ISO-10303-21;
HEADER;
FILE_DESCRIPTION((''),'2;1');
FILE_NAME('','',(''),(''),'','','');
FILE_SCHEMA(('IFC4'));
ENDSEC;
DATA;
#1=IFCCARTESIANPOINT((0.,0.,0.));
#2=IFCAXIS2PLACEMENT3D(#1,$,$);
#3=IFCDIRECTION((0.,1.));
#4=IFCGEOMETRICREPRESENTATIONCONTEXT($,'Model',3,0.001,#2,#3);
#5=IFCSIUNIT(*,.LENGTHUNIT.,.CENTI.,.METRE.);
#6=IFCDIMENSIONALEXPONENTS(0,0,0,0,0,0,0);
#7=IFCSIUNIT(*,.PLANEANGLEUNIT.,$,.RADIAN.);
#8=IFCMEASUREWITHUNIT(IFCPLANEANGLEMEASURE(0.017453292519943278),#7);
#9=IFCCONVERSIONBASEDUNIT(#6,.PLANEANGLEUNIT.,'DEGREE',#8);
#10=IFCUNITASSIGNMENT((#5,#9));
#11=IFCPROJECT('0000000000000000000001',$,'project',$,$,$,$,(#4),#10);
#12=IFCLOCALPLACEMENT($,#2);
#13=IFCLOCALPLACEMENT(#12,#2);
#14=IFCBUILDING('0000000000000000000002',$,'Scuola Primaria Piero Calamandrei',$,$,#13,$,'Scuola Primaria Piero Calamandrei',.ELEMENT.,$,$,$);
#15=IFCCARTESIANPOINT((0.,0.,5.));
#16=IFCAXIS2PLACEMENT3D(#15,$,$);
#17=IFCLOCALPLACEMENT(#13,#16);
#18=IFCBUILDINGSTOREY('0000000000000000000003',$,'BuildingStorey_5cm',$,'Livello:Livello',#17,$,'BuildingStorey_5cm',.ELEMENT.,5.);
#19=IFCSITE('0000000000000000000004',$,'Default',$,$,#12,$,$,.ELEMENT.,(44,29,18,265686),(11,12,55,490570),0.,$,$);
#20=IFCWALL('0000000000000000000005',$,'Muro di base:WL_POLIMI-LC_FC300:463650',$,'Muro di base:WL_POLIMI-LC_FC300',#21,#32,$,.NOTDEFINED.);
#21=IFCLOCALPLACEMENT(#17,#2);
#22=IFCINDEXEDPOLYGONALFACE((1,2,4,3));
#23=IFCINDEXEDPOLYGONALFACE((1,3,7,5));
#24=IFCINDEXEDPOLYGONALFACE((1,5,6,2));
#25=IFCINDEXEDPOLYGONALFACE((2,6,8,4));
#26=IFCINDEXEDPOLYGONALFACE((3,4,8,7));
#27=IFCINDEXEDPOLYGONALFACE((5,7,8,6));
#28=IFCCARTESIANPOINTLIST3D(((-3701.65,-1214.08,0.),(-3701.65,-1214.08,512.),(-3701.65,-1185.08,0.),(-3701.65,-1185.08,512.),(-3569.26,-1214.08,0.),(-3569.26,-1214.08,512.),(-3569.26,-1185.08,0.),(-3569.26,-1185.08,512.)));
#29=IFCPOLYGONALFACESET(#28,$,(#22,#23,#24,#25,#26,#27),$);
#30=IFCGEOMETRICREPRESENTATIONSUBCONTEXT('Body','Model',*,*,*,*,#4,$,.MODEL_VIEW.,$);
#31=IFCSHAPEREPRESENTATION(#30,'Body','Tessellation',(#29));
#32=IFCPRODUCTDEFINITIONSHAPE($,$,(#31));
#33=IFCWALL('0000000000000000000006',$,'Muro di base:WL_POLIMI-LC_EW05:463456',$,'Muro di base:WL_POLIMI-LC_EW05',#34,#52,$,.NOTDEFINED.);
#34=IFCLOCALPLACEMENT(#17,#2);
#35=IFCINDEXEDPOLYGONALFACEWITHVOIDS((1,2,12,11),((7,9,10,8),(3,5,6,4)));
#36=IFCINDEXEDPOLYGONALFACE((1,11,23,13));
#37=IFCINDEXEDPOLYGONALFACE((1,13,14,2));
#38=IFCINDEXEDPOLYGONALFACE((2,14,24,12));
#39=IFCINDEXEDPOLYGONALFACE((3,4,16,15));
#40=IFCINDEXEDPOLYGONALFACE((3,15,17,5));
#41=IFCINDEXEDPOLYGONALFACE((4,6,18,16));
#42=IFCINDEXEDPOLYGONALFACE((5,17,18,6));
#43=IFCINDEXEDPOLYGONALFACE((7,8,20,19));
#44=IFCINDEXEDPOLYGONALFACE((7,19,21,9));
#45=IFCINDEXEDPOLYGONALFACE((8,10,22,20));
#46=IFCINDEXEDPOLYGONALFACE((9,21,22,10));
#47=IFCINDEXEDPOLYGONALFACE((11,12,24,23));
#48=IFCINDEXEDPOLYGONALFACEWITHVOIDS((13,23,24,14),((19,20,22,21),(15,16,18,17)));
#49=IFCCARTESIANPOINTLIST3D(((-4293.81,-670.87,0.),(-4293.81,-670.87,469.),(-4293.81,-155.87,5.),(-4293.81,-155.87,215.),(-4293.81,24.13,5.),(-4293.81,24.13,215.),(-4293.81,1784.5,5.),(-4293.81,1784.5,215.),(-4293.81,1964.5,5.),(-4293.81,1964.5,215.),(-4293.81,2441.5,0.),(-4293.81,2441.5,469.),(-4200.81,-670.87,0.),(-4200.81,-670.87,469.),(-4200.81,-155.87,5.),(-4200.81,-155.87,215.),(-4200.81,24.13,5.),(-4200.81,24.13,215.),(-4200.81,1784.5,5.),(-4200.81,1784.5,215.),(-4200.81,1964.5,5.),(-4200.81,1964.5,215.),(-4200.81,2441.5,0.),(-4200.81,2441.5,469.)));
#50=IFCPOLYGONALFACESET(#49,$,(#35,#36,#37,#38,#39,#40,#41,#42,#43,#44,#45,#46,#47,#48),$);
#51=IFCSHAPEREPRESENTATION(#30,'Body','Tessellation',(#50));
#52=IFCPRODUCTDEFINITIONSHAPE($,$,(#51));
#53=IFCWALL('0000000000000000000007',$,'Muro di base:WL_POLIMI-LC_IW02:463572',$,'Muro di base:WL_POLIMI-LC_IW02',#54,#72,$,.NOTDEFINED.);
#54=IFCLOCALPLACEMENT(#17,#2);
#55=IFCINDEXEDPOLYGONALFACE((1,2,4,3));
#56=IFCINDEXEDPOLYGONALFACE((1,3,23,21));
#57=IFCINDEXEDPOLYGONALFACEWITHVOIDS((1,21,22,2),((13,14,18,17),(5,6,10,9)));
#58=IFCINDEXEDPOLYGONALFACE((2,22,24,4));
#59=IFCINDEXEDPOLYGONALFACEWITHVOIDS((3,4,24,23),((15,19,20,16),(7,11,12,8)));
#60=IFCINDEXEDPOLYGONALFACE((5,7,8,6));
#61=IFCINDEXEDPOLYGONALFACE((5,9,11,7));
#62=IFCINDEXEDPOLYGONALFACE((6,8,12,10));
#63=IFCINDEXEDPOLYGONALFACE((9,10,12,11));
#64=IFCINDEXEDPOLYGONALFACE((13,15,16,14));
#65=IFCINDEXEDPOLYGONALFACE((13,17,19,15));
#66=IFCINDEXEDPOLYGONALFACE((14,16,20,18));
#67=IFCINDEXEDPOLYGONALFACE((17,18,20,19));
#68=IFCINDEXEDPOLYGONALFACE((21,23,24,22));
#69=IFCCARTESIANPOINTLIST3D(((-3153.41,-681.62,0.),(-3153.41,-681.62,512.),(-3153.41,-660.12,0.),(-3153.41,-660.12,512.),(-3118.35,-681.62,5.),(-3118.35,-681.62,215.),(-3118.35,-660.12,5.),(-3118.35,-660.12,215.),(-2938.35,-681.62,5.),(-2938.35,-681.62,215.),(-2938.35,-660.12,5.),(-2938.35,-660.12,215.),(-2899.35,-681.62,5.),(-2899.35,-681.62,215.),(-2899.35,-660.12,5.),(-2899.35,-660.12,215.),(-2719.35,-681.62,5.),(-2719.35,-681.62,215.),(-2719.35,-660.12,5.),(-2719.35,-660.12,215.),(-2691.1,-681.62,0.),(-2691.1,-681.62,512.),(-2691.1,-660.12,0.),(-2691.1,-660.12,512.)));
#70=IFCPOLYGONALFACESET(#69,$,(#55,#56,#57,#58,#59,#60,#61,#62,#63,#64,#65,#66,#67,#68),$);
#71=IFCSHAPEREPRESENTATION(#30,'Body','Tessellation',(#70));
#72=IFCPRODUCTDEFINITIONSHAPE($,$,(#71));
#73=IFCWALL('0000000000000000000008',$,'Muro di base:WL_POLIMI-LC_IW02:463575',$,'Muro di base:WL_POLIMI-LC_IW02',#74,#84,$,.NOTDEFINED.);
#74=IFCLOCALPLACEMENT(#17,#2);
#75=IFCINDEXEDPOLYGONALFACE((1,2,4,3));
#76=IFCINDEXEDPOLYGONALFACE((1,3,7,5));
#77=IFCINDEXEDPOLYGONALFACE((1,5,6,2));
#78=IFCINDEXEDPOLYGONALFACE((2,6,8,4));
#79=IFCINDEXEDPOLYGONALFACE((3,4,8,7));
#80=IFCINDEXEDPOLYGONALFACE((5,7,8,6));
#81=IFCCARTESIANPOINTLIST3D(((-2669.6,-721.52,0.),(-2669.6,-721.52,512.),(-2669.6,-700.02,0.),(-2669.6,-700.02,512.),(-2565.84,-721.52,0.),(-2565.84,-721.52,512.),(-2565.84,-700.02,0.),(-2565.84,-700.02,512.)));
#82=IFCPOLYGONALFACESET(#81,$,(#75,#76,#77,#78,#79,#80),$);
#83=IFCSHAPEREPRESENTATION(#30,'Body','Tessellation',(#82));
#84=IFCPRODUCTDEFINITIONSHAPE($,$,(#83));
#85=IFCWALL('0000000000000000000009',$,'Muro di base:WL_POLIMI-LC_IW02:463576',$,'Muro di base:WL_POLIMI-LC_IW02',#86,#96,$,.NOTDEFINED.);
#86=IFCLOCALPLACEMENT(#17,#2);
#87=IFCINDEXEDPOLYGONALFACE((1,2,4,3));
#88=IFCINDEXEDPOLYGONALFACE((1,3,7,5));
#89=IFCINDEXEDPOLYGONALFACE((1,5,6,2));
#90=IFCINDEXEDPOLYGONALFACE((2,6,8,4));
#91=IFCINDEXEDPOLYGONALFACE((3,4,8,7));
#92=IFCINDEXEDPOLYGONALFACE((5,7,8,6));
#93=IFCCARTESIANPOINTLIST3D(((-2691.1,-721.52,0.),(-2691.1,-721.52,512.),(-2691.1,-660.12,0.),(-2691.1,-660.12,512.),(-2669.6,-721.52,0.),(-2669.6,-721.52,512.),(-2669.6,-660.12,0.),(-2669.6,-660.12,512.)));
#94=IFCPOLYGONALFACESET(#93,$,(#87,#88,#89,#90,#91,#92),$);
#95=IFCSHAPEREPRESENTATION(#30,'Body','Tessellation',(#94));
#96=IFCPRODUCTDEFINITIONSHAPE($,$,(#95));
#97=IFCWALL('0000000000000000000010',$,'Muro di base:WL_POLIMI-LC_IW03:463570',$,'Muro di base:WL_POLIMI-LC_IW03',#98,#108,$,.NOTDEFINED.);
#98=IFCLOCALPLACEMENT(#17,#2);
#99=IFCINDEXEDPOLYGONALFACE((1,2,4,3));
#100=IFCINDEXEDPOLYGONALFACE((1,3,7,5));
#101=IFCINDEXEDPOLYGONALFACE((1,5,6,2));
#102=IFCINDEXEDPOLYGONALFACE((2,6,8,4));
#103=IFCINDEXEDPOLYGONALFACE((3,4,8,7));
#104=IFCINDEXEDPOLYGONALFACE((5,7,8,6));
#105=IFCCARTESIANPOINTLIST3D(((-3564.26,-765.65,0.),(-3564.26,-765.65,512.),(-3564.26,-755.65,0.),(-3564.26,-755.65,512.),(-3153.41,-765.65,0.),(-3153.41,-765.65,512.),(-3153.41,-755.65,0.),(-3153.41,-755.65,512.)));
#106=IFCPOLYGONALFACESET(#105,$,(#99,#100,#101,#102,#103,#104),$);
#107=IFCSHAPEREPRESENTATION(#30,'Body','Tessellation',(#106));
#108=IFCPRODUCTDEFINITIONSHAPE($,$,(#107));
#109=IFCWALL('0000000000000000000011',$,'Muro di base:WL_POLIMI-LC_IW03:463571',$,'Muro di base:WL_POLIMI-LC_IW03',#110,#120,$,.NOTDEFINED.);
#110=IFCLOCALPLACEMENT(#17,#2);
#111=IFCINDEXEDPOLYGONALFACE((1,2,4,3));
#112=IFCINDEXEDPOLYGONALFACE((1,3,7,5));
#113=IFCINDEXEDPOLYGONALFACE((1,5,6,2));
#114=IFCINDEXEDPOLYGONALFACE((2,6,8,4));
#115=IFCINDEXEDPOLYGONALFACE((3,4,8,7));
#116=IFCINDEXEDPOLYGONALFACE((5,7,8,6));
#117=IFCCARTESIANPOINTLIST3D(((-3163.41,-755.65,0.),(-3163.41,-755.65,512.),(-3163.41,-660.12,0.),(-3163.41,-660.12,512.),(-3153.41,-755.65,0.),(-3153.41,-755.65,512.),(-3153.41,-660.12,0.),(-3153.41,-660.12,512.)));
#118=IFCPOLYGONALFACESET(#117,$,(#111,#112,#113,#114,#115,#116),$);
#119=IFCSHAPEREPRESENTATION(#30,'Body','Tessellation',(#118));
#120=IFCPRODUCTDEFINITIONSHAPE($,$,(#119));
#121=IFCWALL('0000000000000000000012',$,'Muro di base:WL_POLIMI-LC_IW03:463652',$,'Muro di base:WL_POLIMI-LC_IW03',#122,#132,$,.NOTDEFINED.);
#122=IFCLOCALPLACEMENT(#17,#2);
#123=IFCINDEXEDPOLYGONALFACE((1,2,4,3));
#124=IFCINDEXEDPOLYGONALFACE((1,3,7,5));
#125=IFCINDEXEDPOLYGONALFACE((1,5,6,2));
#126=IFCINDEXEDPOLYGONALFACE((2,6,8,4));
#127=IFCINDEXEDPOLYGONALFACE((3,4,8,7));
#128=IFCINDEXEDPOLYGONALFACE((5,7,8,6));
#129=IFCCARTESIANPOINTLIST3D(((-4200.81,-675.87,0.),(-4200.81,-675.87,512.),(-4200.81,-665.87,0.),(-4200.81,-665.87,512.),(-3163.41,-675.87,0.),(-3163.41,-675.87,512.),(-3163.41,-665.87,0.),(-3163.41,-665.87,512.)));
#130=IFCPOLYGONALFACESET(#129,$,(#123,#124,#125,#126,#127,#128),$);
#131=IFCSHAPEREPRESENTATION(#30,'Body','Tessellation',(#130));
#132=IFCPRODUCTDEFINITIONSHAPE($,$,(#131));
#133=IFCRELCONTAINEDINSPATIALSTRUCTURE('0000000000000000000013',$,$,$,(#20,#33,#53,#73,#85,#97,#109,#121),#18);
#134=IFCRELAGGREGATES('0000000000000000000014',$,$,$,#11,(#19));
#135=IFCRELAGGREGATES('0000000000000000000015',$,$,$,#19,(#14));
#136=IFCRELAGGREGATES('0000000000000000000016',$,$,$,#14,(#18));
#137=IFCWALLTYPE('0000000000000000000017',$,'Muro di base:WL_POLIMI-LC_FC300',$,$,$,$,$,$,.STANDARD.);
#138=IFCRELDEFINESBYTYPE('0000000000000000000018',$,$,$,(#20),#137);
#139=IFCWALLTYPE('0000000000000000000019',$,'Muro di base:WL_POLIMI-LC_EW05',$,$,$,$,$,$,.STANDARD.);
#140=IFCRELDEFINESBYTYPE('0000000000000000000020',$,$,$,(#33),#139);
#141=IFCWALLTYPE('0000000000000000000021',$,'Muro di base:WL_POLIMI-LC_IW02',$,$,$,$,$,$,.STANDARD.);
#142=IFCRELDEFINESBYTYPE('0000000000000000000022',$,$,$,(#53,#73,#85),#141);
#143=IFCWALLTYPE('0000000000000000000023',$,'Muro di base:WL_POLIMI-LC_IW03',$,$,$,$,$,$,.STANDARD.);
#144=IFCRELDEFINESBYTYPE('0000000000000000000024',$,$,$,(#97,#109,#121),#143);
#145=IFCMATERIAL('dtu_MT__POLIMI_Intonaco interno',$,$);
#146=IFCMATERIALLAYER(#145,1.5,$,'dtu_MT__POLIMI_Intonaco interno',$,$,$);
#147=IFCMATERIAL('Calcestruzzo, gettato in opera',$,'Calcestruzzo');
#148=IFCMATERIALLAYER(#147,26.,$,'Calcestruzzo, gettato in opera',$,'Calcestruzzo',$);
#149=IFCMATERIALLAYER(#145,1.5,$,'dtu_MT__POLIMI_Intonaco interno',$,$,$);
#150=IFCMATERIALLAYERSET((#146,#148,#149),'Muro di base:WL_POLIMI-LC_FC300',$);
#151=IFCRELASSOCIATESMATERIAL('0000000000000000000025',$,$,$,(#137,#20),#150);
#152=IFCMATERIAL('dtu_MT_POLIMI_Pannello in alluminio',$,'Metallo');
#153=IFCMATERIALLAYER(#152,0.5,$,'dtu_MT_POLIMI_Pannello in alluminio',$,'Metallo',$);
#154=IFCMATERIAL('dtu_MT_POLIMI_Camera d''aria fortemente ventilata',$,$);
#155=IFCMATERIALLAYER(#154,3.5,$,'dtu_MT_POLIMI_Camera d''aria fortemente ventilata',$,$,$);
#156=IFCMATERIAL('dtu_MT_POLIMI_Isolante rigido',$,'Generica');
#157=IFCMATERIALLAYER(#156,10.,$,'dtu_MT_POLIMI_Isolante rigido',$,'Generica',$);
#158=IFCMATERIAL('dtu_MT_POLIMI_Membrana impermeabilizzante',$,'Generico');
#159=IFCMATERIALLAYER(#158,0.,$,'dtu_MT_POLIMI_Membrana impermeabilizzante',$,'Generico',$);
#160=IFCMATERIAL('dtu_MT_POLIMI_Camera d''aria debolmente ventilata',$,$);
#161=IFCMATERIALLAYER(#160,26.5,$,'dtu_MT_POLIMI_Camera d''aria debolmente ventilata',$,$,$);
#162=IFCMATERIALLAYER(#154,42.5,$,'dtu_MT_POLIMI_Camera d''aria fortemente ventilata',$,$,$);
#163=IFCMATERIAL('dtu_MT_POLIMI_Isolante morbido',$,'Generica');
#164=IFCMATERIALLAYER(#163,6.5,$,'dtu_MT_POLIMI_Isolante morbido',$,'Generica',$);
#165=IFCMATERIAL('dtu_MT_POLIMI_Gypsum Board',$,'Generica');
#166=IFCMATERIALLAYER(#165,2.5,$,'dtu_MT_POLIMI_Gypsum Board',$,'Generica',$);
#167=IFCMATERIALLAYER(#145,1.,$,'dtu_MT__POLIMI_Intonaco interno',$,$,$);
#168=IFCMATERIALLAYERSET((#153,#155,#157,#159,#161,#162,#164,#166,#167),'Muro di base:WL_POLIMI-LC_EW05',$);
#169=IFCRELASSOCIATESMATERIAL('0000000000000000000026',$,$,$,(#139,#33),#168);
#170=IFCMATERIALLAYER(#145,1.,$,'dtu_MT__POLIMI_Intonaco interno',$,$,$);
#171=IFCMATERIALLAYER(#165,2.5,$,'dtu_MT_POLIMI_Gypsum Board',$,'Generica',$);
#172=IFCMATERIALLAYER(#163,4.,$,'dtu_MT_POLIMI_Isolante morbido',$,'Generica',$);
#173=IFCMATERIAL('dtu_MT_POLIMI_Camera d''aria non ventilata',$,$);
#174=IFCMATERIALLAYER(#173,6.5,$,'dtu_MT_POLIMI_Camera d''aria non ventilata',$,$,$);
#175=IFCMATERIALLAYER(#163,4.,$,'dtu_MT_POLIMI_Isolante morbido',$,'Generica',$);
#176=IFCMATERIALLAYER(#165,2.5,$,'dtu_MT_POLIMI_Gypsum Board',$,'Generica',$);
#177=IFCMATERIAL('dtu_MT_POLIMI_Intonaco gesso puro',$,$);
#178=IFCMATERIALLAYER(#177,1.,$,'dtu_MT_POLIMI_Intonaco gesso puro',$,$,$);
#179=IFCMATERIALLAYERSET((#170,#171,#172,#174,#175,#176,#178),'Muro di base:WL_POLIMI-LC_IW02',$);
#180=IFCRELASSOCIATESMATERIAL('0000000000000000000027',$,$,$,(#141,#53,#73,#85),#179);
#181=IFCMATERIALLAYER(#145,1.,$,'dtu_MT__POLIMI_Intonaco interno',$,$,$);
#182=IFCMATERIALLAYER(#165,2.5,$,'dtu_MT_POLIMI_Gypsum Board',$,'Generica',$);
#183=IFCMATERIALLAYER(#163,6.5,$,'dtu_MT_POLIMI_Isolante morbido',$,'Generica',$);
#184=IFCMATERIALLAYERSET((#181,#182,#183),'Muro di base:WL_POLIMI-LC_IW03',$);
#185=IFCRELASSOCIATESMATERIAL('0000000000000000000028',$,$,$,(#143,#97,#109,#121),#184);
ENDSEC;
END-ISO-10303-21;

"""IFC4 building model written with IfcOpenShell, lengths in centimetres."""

from ifc_helpers import new_model, entity, si_unit, converted_unit, direction, frame, frame_2d, origin, place, context, subcontext, project, spatial, polyline, rectangle, extrude, clip, bounded_halfspace, material, layer, layer_set, layer_usage, type_object, element, save


model = new_model("IFC4")

# Units and contexts
model_context = context("Model", 3, precision=0.001, world=origin(), true_north=direction((0.0, 1.0)))
body_context = subcontext(model_context, "Body", "Model", "MODEL_VIEW")
ifc_project = project(units=[si_unit("LENGTHUNIT", "METRE", prefix="CENTI"), converted_unit("PLANEANGLEUNIT", "DEGREE", entity("IfcPlaneAngleMeasure", 0.017453292519943278), si_unit("PLANEANGLEUNIT", "RADIAN"), dimensions=[0, 0, 0, 0, 0, 0, 0])], contexts=[model_context])

# Site, building, storey
site_placement = place(None, origin())
site = spatial("IfcSite", under=ifc_project, at=site_placement, Name="Default", CompositionType="ELEMENT", RefLatitude=(44, 29, 18, 265686), RefLongitude=(11, 12, 55, 490570), RefElevation=0.0)
building_placement = place(site_placement, origin())
building = spatial("IfcBuilding", under=site, at=building_placement, Name="Scuola Primaria Piero Calamandrei", LongName="Scuola Primaria Piero Calamandrei", CompositionType="ELEMENT")
storey_placement = place(building_placement, frame((0.0, 0.0, 5.0)))
storey = spatial("IfcBuildingStorey", under=building, at=storey_placement, Name="BuildingStorey_5cm", ObjectType="Livello:Livello", LongName="BuildingStorey_5cm", CompositionType="ELEMENT", Elevation=5.0)

# Shared definitions
ifc_material_1 = material(Name="dtu_MT_POLIMI_Isolante rigido", Category="Generica")
ifc_material_2 = material(Name="dtu_MT__POLIMI_Intonaco interno")

# Shared definitions
ifc_material_3 = material(Name="dtu_MT_POLIMI_Intonaco gesso puro")

# Wall
ifc_layer_1 = layer(ifc_material_2, 1.5, Name="dtu_MT__POLIMI_Intonaco interno")
ifc_material_4 = material(Name="Calcestruzzo, gettato in opera", Category="Calcestruzzo")
ifc_layer_2 = layer(ifc_material_4, 26.0, Name="Calcestruzzo, gettato in opera", Category="Calcestruzzo")
ifc_layer_3 = layer(ifc_material_2, 1.5, Name="dtu_MT__POLIMI_Intonaco interno")
ifc_layer_set_1 = layer_set([ifc_layer_1, ifc_layer_2, ifc_layer_3], Name="Muro di base:WL_POLIMI-LC_FC300")
wall_type_1 = type_object("IfcWallType", Name="Muro di base:WL_POLIMI-LC_FC300", PredefinedType="STANDARD", material=ifc_layer_set_1)
ifc_layer_usage_1 = layer_usage(ifc_layer_set_1, "AXIS2", "NEGATIVE", 14.5)
wall_1_placement = place(storey_placement, frame((-3701.65, -1199.58, 0.0)))
element("IfcWall", 1, at=wall_1_placement, inside=storey, type_object=wall_type_1, material=ifc_layer_usage_1, Name="Muro di base:WL_POLIMI-LC_FC300:463650", ObjectType="Muro di base:WL_POLIMI-LC_FC300", PredefinedType="NOTDEFINED", context=body_context, shape_type="SweptSolid", body=[
    extrude(rectangle(XDim=132.39, YDim=29.0, at=frame_2d((66.2, 0.0), x_axis=(-1.0, 0.0))), origin(), (0.0, 0.0, 1.0), 512.0),
])

# Walls, openings
ifc_material_5 = material(Name="dtu_MT_POLIMI_Pannello in alluminio", Category="Metallo")
ifc_layer_4 = layer(ifc_material_5, 0.5, Name="dtu_MT_POLIMI_Pannello in alluminio", Category="Metallo")
ifc_material_6 = material(Name="dtu_MT_POLIMI_Camera d'aria fortemente ventilata")
ifc_layer_5 = layer(ifc_material_6, 3.5, Name="dtu_MT_POLIMI_Camera d'aria fortemente ventilata")
ifc_layer_6 = layer(ifc_material_1, 10.0, Name="dtu_MT_POLIMI_Isolante rigido", Category="Generica")
ifc_material_7 = material(Name="dtu_MT_POLIMI_Membrana impermeabilizzante", Category="Generico")
ifc_layer_7 = layer(ifc_material_7, 0.0, Name="dtu_MT_POLIMI_Membrana impermeabilizzante", Category="Generico")
ifc_material_8 = material(Name="dtu_MT_POLIMI_Camera d'aria debolmente ventilata")
ifc_layer_8 = layer(ifc_material_8, 26.5, Name="dtu_MT_POLIMI_Camera d'aria debolmente ventilata")
ifc_layer_9 = layer(ifc_material_6, 42.5, Name="dtu_MT_POLIMI_Camera d'aria fortemente ventilata")
ifc_material_9 = material(Name="dtu_MT_POLIMI_Isolante morbido", Category="Generica")
ifc_layer_10 = layer(ifc_material_9, 6.5, Name="dtu_MT_POLIMI_Isolante morbido", Category="Generica")
ifc_material_10 = material(Name="dtu_MT_POLIMI_Gypsum Board", Category="Generica")
ifc_layer_11 = layer(ifc_material_10, 2.5, Name="dtu_MT_POLIMI_Gypsum Board", Category="Generica")
ifc_layer_12 = layer(ifc_material_2, 1.0, Name="dtu_MT__POLIMI_Intonaco interno")
ifc_layer_set_2 = layer_set([ifc_layer_4, ifc_layer_5, ifc_layer_6, ifc_layer_7, ifc_layer_8, ifc_layer_9, ifc_layer_10, ifc_layer_11, ifc_layer_12], Name="Muro di base:WL_POLIMI-LC_EW05")
ifc_layer_usage_2 = layer_usage(ifc_layer_set_2, "AXIS2", "NEGATIVE", 46.5)
wall_type_2 = type_object("IfcWallType", Name="Muro di base:WL_POLIMI-LC_EW05", PredefinedType="STANDARD", material=ifc_layer_set_2)
wall_2_placement = place(storey_placement, frame((-4247.31, -670.87, 0.0), z_axis=(0.0, 0.0, 1.0), x_axis=(0.0, 1.0, 0.0)))
wall_2 = element("IfcWall", 2, at=wall_2_placement, inside=storey, type_object=wall_type_2, material=ifc_layer_usage_2, Name="Muro di base:WL_POLIMI-LC_EW05:463456", ObjectType="Muro di base:WL_POLIMI-LC_EW05", PredefinedType="NOTDEFINED", context=body_context, shape_type="Clipping", body=[
    clip(extrude(rectangle(XDim=3112.37, YDim=93.0, at=frame_2d((1556.19, 0.0), x_axis=(-1.0, 0.0))), origin(), (0.0, 0.0, 1.0), 469.0), bounded_halfspace(frame((1855.45, -46.5, 469.0), z_axis=(0.0, 0.0, -1.0), x_axis=(0.0, -1.0, 0.0)), True, frame((1855.45, -46.5, 469.0)), polyline([(0.0, 0.0), (1256.92, 0.0), (1256.92, 93.0), (0.0, 93.0), (0.0, 0.0)]))),
])
opening_1_placement = place(wall_2_placement, frame((2455.37, -46.5, 5.0)))
element("IfcOpeningElement", 3, at=opening_1_placement, cuts=wall_2, PredefinedType="OPENING", context=body_context, shape_type="SweptSolid", body=[
    extrude(rectangle(XDim=210.0, YDim=180.0, at=frame_2d((105.0, 90.0), x_axis=(-1.0, 0.0))), frame((0.0, 0.0, 0.0), z_axis=(0.0, 1.0, 0.0), x_axis=(0.0, 0.0, 1.0)), (0.0, 0.0, 1.0), 93.0),
])
opening_2_placement = place(wall_2_placement, frame((515.0, -46.5, 5.0)))
element("IfcOpeningElement", 4, at=opening_2_placement, cuts=wall_2, PredefinedType="OPENING", context=body_context, shape_type="SweptSolid", body=[
    extrude(rectangle(XDim=210.0, YDim=180.0, at=frame_2d((105.0, 90.0), x_axis=(-1.0, 0.0))), frame((0.0, 0.0, 0.0), z_axis=(0.0, 1.0, 0.0), x_axis=(0.0, 0.0, 1.0)), (0.0, 0.0, 1.0), 93.0),
])
ifc_layer_13 = layer(ifc_material_2, 1.0, Name="dtu_MT__POLIMI_Intonaco interno")
ifc_layer_14 = layer(ifc_material_10, 2.5, Name="dtu_MT_POLIMI_Gypsum Board", Category="Generica")
ifc_layer_15 = layer(ifc_material_9, 4.0, Name="dtu_MT_POLIMI_Isolante morbido", Category="Generica")
ifc_material_11 = material(Name="dtu_MT_POLIMI_Camera d'aria non ventilata")
ifc_layer_16 = layer(ifc_material_11, 6.5, Name="dtu_MT_POLIMI_Camera d'aria non ventilata")
ifc_layer_17 = layer(ifc_material_9, 4.0, Name="dtu_MT_POLIMI_Isolante morbido", Category="Generica")
ifc_layer_18 = layer(ifc_material_10, 2.5, Name="dtu_MT_POLIMI_Gypsum Board", Category="Generica")
ifc_layer_19 = layer(ifc_material_3, 1.0, Name="dtu_MT_POLIMI_Intonaco gesso puro")
ifc_layer_set_3 = layer_set([ifc_layer_13, ifc_layer_14, ifc_layer_15, ifc_layer_16, ifc_layer_17, ifc_layer_18, ifc_layer_19], Name="Muro di base:WL_POLIMI-LC_IW02")
ifc_layer_usage_3 = layer_usage(ifc_layer_set_3, "AXIS2", "NEGATIVE", 10.75)
wall_type_3 = type_object("IfcWallType", Name="Muro di base:WL_POLIMI-LC_IW02", PredefinedType="STANDARD", material=ifc_layer_set_3)
wall_3_placement = place(storey_placement, frame((-3153.41, -670.87, 0.0)))
wall_3 = element("IfcWall", 5, at=wall_3_placement, inside=storey, type_object=wall_type_3, material=ifc_layer_usage_3, Name="Muro di base:WL_POLIMI-LC_IW02:463572", ObjectType="Muro di base:WL_POLIMI-LC_IW02", PredefinedType="NOTDEFINED", context=body_context, shape_type="SweptSolid", body=[
    extrude(rectangle(XDim=462.31, YDim=21.5, at=frame_2d((231.16, 0.0), x_axis=(-1.0, 0.0))), origin(), (0.0, 0.0, 1.0), 512.0),
])
opening_3_placement = place(wall_3_placement, frame((434.06, 10.75, 5.0)))
element("IfcOpeningElement", 6, at=opening_3_placement, cuts=wall_3, PredefinedType="OPENING", context=body_context, shape_type="SweptSolid", body=[
    extrude(rectangle(XDim=210.0, YDim=180.0, at=frame_2d((105.0, 90.0), x_axis=(-1.0, 0.0))), frame((0.0, 0.0, 0.0), z_axis=(0.0, -1.0, 0.0), x_axis=(0.0, 0.0, 1.0)), (0.0, 0.0, 1.0), 21.5),
])
opening_4_placement = place(wall_3_placement, frame((215.06, 10.75, 5.0)))
element("IfcOpeningElement", 7, at=opening_4_placement, cuts=wall_3, PredefinedType="OPENING", context=body_context, shape_type="SweptSolid", body=[
    extrude(rectangle(XDim=210.0, YDim=180.0, at=frame_2d((105.0, 90.0), x_axis=(-1.0, 0.0))), frame((0.0, 0.0, 0.0), z_axis=(0.0, -1.0, 0.0), x_axis=(0.0, 0.0, 1.0)), (0.0, 0.0, 1.0), 21.5),
])

# Walls
ifc_layer_usage_4 = layer_usage(ifc_layer_set_3, "AXIS2", "NEGATIVE", 10.75)
wall_4_placement = place(storey_placement, frame((-2669.6, -710.77, 0.0)))
element("IfcWall", 8, at=wall_4_placement, inside=storey, type_object=wall_type_3, material=ifc_layer_usage_4, Name="Muro di base:WL_POLIMI-LC_IW02:463575", ObjectType="Muro di base:WL_POLIMI-LC_IW02", PredefinedType="NOTDEFINED", context=body_context, shape_type="SweptSolid", body=[
    extrude(rectangle(XDim=103.77, YDim=21.5, at=frame_2d((51.88, 0.0), x_axis=(-1.0, 0.0))), origin(), (0.0, 0.0, 1.0), 512.0),
])
ifc_layer_usage_5 = layer_usage(ifc_layer_set_3, "AXIS2", "NEGATIVE", 10.75)
wall_5_placement = place(storey_placement, frame((-2680.35, -660.12, 0.0), z_axis=(0.0, 0.0, 1.0), x_axis=(0.0, -1.0, 0.0)))
element("IfcWall", 9, at=wall_5_placement, inside=storey, type_object=wall_type_3, material=ifc_layer_usage_5, Name="Muro di base:WL_POLIMI-LC_IW02:463576", ObjectType="Muro di base:WL_POLIMI-LC_IW02", PredefinedType="NOTDEFINED", context=body_context, shape_type="SweptSolid", body=[
    extrude(rectangle(XDim=61.4, YDim=21.5, at=frame_2d((30.7, 0.0), x_axis=(-1.0, 0.0))), origin(), (0.0, 0.0, 1.0), 512.0),
])
ifc_layer_20 = layer(ifc_material_2, 1.0, Name="dtu_MT__POLIMI_Intonaco interno")
ifc_layer_21 = layer(ifc_material_10, 2.5, Name="dtu_MT_POLIMI_Gypsum Board", Category="Generica")
ifc_layer_22 = layer(ifc_material_9, 6.5, Name="dtu_MT_POLIMI_Isolante morbido", Category="Generica")
ifc_layer_set_4 = layer_set([ifc_layer_20, ifc_layer_21, ifc_layer_22], Name="Muro di base:WL_POLIMI-LC_IW03")
ifc_layer_usage_6 = layer_usage(ifc_layer_set_4, "AXIS2", "NEGATIVE", 5.0)
wall_type_4 = type_object("IfcWallType", Name="Muro di base:WL_POLIMI-LC_IW03", PredefinedType="STANDARD", material=ifc_layer_set_4)
wall_6_placement = place(storey_placement, frame((-3564.26, -760.65, 0.0)))
element("IfcWall", 10, at=wall_6_placement, inside=storey, type_object=wall_type_4, material=ifc_layer_usage_6, Name="Muro di base:WL_POLIMI-LC_IW03:463570", ObjectType="Muro di base:WL_POLIMI-LC_IW03", PredefinedType="NOTDEFINED", context=body_context, shape_type="SweptSolid", body=[
    extrude(rectangle(XDim=410.84, YDim=10.0, at=frame_2d((205.42, 0.0), x_axis=(-1.0, 0.0))), origin(), (0.0, 0.0, 1.0), 512.0),
])
ifc_layer_usage_7 = layer_usage(ifc_layer_set_4, "AXIS2", "NEGATIVE", 5.0)
wall_7_placement = place(storey_placement, frame((-3158.41, -755.65, 0.0), z_axis=(0.0, 0.0, 1.0), x_axis=(0.0, 1.0, 0.0)))
element("IfcWall", 11, at=wall_7_placement, inside=storey, type_object=wall_type_4, material=ifc_layer_usage_7, Name="Muro di base:WL_POLIMI-LC_IW03:463571", ObjectType="Muro di base:WL_POLIMI-LC_IW03", PredefinedType="NOTDEFINED", context=body_context, shape_type="SweptSolid", body=[
    extrude(rectangle(XDim=95.53, YDim=10.0, at=frame_2d((47.77, 0.0), x_axis=(-1.0, 0.0))), origin(), (0.0, 0.0, 1.0), 512.0),
])
ifc_layer_usage_8 = layer_usage(ifc_layer_set_4, "AXIS2", "NEGATIVE", 5.0)
wall_8_placement = place(storey_placement, frame((-4200.81, -670.87, 0.0)))
element("IfcWall", 12, at=wall_8_placement, inside=storey, type_object=wall_type_4, material=ifc_layer_usage_8, Name="Muro di base:WL_POLIMI-LC_IW03:463652", ObjectType="Muro di base:WL_POLIMI-LC_IW03", PredefinedType="NOTDEFINED", context=body_context, shape_type="SweptSolid", body=[
    extrude(rectangle(XDim=1037.4, YDim=10.0, at=frame_2d((518.7, 0.0), x_axis=(-1.0, 0.0))), origin(), (0.0, 0.0, 1.0), 512.0),
])

save(model, "model.ifc")
